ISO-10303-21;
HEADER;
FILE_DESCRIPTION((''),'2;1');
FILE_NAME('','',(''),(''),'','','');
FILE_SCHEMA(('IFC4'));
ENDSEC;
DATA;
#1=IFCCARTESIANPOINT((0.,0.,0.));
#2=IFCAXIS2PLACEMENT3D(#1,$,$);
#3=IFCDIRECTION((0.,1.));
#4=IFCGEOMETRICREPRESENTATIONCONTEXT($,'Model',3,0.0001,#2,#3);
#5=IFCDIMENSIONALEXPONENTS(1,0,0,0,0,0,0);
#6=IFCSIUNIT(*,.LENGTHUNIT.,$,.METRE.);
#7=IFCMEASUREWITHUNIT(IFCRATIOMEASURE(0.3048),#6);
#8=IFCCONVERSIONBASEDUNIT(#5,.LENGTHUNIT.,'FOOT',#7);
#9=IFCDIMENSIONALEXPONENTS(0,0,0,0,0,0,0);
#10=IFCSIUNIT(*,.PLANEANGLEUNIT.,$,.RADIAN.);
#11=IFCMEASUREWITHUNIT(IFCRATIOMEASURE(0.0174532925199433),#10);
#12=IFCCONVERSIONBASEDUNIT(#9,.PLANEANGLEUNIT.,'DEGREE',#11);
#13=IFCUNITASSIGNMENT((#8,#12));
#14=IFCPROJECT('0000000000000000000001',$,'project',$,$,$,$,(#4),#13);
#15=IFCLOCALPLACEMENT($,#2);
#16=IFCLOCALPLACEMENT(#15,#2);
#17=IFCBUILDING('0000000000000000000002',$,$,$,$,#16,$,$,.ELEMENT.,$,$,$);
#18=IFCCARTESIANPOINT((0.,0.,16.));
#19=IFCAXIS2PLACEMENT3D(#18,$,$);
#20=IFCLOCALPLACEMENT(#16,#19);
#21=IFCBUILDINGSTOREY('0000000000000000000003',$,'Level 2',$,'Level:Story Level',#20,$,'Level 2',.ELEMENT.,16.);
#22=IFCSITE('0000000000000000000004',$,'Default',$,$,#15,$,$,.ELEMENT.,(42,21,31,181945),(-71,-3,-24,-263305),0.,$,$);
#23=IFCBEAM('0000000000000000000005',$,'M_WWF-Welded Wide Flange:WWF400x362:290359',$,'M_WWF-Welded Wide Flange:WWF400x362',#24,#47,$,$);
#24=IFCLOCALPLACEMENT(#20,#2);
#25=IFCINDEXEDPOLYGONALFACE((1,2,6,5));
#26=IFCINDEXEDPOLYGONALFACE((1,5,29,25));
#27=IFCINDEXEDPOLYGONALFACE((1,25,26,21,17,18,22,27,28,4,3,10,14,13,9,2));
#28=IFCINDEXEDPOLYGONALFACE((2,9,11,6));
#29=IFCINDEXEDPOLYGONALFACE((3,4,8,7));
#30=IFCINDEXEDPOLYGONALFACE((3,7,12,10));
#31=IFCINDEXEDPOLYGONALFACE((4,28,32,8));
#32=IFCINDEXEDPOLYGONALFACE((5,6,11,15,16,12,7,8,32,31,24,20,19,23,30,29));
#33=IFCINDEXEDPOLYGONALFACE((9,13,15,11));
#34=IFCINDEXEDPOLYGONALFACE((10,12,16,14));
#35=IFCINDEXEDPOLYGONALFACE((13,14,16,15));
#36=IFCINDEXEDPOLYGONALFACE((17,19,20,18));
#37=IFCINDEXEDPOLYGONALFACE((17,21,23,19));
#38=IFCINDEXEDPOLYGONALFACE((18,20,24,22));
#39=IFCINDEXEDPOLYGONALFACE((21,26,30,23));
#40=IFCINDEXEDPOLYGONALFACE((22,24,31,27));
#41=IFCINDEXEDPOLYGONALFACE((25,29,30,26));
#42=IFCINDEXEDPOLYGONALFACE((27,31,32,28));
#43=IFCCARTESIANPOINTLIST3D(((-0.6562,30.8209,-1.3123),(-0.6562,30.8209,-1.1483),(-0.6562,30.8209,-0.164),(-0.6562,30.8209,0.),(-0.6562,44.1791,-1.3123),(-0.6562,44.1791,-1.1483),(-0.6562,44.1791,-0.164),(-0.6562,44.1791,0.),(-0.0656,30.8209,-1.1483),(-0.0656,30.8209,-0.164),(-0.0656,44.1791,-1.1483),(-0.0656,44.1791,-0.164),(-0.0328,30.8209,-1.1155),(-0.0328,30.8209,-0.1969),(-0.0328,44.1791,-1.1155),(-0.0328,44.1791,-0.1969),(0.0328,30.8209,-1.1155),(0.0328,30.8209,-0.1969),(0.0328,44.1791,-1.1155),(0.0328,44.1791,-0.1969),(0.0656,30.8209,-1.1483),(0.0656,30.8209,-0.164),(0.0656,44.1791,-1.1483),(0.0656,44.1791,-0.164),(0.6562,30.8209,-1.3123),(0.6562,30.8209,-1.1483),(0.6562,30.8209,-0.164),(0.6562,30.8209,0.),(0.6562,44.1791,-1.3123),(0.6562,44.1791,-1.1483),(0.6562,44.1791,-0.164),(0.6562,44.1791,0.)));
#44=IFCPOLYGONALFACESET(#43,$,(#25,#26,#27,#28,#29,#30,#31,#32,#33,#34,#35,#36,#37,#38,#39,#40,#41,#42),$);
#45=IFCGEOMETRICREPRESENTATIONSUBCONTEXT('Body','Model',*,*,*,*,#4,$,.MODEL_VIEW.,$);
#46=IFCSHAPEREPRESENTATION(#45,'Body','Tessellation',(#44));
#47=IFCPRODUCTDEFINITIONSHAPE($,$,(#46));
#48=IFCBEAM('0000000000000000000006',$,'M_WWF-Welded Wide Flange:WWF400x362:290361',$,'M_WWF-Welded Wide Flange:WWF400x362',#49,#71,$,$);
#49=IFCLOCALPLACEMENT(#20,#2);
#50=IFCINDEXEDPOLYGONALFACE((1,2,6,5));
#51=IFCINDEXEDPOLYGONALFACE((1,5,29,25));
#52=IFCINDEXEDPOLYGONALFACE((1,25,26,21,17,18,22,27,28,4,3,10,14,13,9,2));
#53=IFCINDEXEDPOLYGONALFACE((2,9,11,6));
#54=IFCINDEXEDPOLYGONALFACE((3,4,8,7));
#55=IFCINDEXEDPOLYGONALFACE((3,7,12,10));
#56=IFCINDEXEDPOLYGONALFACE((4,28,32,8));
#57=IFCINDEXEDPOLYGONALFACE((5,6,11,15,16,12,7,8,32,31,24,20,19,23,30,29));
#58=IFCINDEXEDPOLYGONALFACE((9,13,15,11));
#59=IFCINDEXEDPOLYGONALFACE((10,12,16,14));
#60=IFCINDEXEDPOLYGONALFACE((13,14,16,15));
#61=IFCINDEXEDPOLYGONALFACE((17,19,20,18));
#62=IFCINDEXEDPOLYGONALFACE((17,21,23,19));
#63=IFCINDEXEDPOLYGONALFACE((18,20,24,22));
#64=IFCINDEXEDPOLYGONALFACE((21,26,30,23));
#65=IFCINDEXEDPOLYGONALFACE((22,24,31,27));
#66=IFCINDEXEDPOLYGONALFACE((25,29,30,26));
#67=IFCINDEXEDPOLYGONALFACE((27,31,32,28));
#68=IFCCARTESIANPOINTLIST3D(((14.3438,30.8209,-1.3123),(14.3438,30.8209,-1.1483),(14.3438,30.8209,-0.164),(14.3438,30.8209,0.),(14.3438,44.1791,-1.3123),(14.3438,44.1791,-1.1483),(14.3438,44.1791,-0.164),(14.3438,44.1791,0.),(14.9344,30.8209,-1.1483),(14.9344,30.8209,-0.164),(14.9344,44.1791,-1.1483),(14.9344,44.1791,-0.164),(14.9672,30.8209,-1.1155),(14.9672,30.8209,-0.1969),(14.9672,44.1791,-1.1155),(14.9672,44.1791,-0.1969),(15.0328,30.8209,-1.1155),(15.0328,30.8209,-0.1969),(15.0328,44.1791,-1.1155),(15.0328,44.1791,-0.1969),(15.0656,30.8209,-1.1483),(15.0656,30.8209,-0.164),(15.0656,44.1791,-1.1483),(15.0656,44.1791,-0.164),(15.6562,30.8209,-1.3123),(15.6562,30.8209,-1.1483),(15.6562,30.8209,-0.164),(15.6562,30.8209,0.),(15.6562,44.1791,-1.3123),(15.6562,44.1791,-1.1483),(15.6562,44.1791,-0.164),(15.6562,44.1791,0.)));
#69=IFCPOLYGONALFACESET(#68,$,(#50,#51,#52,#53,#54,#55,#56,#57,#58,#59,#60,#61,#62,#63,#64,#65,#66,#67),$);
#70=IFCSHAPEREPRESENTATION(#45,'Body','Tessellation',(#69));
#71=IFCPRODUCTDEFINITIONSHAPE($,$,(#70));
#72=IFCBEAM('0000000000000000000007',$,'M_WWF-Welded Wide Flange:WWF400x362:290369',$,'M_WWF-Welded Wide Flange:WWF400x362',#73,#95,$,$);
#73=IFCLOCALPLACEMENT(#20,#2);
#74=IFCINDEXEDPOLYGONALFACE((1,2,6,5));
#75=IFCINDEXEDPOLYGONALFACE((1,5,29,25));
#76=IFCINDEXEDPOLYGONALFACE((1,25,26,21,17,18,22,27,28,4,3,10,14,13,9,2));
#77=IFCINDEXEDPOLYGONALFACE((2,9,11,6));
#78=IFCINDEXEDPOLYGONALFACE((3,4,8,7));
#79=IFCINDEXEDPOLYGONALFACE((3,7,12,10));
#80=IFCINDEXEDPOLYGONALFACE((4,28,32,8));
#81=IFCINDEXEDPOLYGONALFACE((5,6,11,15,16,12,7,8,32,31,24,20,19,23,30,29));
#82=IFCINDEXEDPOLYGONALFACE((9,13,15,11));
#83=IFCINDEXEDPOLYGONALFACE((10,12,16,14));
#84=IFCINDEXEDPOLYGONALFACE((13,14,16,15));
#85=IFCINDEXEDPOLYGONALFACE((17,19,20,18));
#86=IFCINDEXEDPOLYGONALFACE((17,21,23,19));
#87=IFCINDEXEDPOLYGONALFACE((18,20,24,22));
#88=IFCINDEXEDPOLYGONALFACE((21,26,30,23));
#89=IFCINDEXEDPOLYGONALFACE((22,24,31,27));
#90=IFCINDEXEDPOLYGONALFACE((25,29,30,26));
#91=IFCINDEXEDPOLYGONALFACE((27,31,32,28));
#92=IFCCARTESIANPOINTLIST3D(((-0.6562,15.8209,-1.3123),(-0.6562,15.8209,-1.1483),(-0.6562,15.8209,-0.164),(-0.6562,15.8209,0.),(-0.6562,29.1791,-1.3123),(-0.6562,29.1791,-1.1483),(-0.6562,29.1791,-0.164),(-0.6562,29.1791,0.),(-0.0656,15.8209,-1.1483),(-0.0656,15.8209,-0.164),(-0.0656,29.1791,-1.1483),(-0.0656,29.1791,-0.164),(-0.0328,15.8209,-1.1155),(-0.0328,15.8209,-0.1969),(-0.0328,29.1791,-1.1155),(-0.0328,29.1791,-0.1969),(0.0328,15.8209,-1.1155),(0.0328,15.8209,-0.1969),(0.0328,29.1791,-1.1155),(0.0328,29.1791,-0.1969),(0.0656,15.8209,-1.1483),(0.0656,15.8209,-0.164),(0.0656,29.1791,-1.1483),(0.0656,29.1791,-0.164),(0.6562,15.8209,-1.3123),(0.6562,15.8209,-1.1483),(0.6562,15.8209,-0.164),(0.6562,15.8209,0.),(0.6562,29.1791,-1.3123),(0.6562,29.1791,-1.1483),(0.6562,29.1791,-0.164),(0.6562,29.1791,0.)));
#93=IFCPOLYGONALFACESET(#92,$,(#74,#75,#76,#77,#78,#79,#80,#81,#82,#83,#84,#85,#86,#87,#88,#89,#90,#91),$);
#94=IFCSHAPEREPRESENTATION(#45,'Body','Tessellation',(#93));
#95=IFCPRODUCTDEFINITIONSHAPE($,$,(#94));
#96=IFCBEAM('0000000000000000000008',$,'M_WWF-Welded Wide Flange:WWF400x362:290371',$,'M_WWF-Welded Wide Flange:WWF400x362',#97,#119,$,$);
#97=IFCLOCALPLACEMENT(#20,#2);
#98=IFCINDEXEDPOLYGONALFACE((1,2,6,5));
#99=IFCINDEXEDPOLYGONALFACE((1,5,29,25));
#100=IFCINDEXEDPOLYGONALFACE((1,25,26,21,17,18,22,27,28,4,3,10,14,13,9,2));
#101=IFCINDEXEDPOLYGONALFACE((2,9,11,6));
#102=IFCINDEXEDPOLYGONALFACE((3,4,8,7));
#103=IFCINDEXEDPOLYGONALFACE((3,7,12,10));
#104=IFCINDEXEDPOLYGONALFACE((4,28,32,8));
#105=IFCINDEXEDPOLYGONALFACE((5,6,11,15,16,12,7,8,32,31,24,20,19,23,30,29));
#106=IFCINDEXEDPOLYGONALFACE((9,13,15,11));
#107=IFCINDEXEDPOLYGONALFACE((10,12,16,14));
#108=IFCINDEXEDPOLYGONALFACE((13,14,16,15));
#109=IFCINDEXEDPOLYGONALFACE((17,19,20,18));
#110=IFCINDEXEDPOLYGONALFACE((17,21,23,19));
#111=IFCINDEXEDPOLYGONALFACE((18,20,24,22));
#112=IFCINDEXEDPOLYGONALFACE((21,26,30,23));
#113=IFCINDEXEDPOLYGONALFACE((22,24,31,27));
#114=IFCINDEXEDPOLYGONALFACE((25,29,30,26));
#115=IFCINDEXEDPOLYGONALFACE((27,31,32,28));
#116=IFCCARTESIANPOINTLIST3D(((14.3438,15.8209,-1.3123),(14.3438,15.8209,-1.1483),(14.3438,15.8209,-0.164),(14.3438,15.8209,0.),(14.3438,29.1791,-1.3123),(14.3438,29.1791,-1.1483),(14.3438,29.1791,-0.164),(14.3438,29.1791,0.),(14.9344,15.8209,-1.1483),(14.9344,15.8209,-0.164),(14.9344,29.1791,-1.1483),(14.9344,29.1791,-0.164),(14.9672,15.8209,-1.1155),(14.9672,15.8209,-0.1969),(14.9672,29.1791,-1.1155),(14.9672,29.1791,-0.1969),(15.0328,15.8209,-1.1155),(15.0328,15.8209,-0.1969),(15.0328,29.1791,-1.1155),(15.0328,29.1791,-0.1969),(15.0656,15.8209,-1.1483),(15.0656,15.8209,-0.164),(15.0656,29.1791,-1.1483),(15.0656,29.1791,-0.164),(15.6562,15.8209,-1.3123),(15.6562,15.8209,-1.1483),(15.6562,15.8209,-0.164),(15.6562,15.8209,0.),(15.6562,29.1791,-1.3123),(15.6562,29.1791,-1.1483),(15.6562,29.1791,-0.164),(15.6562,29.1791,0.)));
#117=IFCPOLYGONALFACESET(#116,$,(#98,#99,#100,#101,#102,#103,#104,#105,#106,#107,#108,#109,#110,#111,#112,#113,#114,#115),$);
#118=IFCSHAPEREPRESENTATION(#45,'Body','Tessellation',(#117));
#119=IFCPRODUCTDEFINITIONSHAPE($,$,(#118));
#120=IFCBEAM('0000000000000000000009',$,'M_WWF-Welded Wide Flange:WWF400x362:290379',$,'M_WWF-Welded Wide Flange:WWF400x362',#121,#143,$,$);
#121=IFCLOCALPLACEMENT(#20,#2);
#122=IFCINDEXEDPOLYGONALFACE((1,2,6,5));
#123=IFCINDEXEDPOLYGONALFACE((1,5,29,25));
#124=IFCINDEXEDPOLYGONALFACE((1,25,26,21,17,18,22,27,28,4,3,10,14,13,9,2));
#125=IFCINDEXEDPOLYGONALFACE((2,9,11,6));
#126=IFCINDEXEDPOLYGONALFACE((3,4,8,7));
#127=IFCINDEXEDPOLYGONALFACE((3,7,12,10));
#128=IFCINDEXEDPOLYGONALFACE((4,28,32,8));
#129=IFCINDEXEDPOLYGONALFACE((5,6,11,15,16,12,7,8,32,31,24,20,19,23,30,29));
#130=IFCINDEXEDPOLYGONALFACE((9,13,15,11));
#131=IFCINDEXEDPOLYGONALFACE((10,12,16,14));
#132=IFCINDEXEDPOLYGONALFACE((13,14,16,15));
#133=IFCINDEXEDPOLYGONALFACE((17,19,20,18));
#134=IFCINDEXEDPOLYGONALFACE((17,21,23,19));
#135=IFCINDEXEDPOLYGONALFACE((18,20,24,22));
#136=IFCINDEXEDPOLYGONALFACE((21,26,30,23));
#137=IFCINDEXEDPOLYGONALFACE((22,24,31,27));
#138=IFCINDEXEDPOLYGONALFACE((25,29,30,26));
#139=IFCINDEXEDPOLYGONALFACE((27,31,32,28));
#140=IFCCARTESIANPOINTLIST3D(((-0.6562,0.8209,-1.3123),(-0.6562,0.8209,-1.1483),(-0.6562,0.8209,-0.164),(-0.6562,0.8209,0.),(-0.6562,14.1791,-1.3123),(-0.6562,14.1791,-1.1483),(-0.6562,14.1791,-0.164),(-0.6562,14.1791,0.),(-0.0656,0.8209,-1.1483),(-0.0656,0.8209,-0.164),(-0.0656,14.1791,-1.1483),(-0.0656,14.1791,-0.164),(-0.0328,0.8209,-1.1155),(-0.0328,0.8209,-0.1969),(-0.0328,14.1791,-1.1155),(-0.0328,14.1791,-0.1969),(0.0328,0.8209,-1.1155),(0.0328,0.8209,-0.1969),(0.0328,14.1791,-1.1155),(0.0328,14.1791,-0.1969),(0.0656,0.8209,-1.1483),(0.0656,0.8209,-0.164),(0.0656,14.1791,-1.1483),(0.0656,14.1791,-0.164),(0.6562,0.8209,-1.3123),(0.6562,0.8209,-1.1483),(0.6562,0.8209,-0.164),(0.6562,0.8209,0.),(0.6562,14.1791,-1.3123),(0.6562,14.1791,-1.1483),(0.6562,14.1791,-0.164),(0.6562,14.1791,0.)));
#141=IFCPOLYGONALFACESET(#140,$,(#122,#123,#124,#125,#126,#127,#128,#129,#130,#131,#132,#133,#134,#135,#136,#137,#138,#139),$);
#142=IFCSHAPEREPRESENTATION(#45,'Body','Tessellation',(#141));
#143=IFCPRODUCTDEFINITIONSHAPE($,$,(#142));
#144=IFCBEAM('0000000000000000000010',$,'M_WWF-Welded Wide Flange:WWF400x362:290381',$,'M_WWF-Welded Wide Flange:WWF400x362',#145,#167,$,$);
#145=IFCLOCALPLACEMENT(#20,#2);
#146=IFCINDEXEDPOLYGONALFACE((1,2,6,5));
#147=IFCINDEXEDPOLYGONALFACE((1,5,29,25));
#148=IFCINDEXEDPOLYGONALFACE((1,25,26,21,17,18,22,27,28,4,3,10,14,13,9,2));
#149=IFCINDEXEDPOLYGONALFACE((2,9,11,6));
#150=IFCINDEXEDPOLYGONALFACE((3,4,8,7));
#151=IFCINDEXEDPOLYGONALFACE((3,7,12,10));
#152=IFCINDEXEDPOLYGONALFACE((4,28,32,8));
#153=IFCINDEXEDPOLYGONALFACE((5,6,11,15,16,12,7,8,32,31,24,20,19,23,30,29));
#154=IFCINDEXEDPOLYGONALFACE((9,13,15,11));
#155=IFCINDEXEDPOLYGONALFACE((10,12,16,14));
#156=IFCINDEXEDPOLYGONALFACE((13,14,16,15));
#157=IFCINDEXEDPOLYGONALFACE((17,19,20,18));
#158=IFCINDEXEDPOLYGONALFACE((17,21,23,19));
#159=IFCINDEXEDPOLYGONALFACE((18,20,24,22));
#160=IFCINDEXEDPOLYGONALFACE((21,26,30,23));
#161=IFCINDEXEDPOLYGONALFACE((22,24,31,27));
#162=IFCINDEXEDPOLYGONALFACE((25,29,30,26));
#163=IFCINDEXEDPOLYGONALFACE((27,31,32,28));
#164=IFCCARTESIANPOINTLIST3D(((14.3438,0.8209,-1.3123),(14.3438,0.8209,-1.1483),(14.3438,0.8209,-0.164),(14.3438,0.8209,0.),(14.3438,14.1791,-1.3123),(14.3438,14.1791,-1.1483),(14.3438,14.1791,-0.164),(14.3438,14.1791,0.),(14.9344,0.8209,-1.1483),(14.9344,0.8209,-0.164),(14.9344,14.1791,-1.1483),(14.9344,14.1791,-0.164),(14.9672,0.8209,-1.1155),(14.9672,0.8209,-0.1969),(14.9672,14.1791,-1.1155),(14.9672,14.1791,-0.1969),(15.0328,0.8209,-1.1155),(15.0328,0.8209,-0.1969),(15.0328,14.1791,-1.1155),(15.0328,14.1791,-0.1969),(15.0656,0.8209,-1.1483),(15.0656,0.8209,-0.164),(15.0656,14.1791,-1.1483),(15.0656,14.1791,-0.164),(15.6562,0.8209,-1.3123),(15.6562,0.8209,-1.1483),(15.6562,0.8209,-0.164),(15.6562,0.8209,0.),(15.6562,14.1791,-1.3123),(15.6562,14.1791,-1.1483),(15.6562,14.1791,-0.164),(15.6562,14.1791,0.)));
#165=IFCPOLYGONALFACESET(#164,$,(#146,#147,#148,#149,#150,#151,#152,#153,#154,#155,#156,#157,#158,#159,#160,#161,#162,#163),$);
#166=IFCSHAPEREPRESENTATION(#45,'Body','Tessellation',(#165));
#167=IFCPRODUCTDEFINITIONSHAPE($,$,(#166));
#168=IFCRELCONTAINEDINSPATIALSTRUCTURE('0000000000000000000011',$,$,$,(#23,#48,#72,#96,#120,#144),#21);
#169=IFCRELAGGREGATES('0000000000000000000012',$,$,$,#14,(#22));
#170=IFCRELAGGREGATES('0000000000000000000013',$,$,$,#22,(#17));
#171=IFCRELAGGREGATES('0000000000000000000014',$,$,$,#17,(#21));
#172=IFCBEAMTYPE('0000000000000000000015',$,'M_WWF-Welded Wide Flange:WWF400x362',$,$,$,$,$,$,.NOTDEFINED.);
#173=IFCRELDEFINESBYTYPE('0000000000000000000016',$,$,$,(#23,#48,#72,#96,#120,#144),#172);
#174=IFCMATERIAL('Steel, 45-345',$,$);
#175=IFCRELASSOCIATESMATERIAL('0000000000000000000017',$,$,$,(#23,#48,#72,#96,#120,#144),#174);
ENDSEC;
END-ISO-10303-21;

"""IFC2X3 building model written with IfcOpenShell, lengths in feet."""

from ifc_helpers import new_model, entity, si_unit, converted_unit, direction, frame, origin, place, context, subcontext, project, spatial, polyline, outline, extrude, material, type_object, element, save


model = new_model("IFC2X3")

# Units and contexts
model_context = context("Model", 3, precision=0.0001, world=origin(), true_north=direction((0.0, 1.0)))
body_context = subcontext(model_context, "Body", "Model", "MODEL_VIEW")
ifc_project = project(units=[converted_unit("LENGTHUNIT", "FOOT", entity("IfcRatioMeasure", 0.3048), si_unit("LENGTHUNIT", "METRE"), dimensions=[1, 0, 0, 0, 0, 0, 0]), converted_unit("PLANEANGLEUNIT", "DEGREE", entity("IfcRatioMeasure", 0.0174532925199433), si_unit("PLANEANGLEUNIT", "RADIAN"), dimensions=[0, 0, 0, 0, 0, 0, 0])], contexts=[model_context])

# Site, building, storey
site_placement = place(None, origin())
site = spatial("IfcSite", under=ifc_project, at=site_placement, Name="Default", CompositionType="ELEMENT", RefLatitude=(42, 21, 31, 181945), RefLongitude=(-71, -3, -24, -263305), RefElevation=0.0)
building_placement = place(site_placement, origin())
building = spatial("IfcBuilding", under=site, at=building_placement, CompositionType="ELEMENT")
storey_placement = place(building_placement, frame((0.0, 0.0, 16.0)))
storey = spatial("IfcBuildingStorey", under=building, at=storey_placement, Name="Level 2", ObjectType="Level:Story Level", LongName="Level 2", CompositionType="ELEMENT", Elevation=16.0)

# Shared definitions
ifc_material = material(Name="Steel, 45-345")

# Beams
beam_type = type_object("IfcBeamType", Name="M_WWF-Welded Wide Flange:WWF400x362", PredefinedType="NOTDEFINED")
beam_1_placement = place(storey_placement, frame((0.0, 30.0, 0.0), z_axis=(0.0, 0.0, 1.0), x_axis=(0.0, 1.0, 0.0)))
element("IfcBeam", 1, at=beam_1_placement, inside=storey, type_object=beam_type, material=ifc_material, Name="M_WWF-Welded Wide Flange:WWF400x362:290359", ObjectType="M_WWF-Welded Wide Flange:WWF400x362", context=body_context, shape_type="SweptSolid", body=[
    extrude(outline(polyline([(-0.6562, -0.6562), (-0.4921, -0.6562), (-0.4921, -0.0656), (-0.4593, -0.0328), (0.4593, -0.0328), (0.4921, -0.0656), (0.4921, -0.6562), (0.6562, -0.6562), (0.6562, 0.6562), (0.4921, 0.6562), (0.4921, 0.0656), (0.4593, 0.0328), (-0.4593, 0.0328), (-0.4921, 0.0656), (-0.4921, 0.6562), (-0.6562, 0.6562), (-0.6562, -0.6562)])), frame((0.8209, 0.0, -0.6562), z_axis=(1.0, 0.0, 0.0), x_axis=(0.0, 0.0, -1.0)), (0.0, 0.0, 1.0), 13.3583),
])
beam_2_placement = place(storey_placement, frame((15.0, 30.0, 0.0), z_axis=(0.0, 0.0, 1.0), x_axis=(0.0, 1.0, 0.0)))
element("IfcBeam", 2, at=beam_2_placement, inside=storey, type_object=beam_type, material=ifc_material, Name="M_WWF-Welded Wide Flange:WWF400x362:290361", ObjectType="M_WWF-Welded Wide Flange:WWF400x362", context=body_context, shape_type="SweptSolid", body=[
    extrude(outline(polyline([(-0.6562, -0.6562), (-0.4921, -0.6562), (-0.4921, -0.0656), (-0.4593, -0.0328), (0.4593, -0.0328), (0.4921, -0.0656), (0.4921, -0.6562), (0.6562, -0.6562), (0.6562, 0.6562), (0.4921, 0.6562), (0.4921, 0.0656), (0.4593, 0.0328), (-0.4593, 0.0328), (-0.4921, 0.0656), (-0.4921, 0.6562), (-0.6562, 0.6562), (-0.6562, -0.6562)])), frame((0.8209, 0.0, -0.6562), z_axis=(1.0, 0.0, 0.0), x_axis=(0.0, 0.0, -1.0)), (0.0, 0.0, 1.0), 13.3583),
])
beam_3_placement = place(storey_placement, frame((0.0, 15.0, 0.0), z_axis=(0.0, 0.0, 1.0), x_axis=(0.0, 1.0, 0.0)))
element("IfcBeam", 3, at=beam_3_placement, inside=storey, type_object=beam_type, material=ifc_material, Name="M_WWF-Welded Wide Flange:WWF400x362:290369", ObjectType="M_WWF-Welded Wide Flange:WWF400x362", context=body_context, shape_type="SweptSolid", body=[
    extrude(outline(polyline([(-0.6562, -0.6562), (-0.4921, -0.6562), (-0.4921, -0.0656), (-0.4593, -0.0328), (0.4593, -0.0328), (0.4921, -0.0656), (0.4921, -0.6562), (0.6562, -0.6562), (0.6562, 0.6562), (0.4921, 0.6562), (0.4921, 0.0656), (0.4593, 0.0328), (-0.4593, 0.0328), (-0.4921, 0.0656), (-0.4921, 0.6562), (-0.6562, 0.6562), (-0.6562, -0.6562)])), frame((0.8209, 0.0, -0.6562), z_axis=(1.0, 0.0, 0.0), x_axis=(0.0, 0.0, -1.0)), (0.0, 0.0, 1.0), 13.3583),
])
beam_4_placement = place(storey_placement, frame((15.0, 15.0, 0.0), z_axis=(0.0, 0.0, 1.0), x_axis=(0.0, 1.0, 0.0)))
element("IfcBeam", 4, at=beam_4_placement, inside=storey, type_object=beam_type, material=ifc_material, Name="M_WWF-Welded Wide Flange:WWF400x362:290371", ObjectType="M_WWF-Welded Wide Flange:WWF400x362", context=body_context, shape_type="SweptSolid", body=[
    extrude(outline(polyline([(-0.6562, -0.6562), (-0.4921, -0.6562), (-0.4921, -0.0656), (-0.4593, -0.0328), (0.4593, -0.0328), (0.4921, -0.0656), (0.4921, -0.6562), (0.6562, -0.6562), (0.6562, 0.6562), (0.4921, 0.6562), (0.4921, 0.0656), (0.4593, 0.0328), (-0.4593, 0.0328), (-0.4921, 0.0656), (-0.4921, 0.6562), (-0.6562, 0.6562), (-0.6562, -0.6562)])), frame((0.8209, 0.0, -0.6562), z_axis=(1.0, 0.0, 0.0), x_axis=(0.0, 0.0, -1.0)), (0.0, 0.0, 1.0), 13.3583),
])
beam_5_placement = place(storey_placement, frame((0.0, 0.0, 0.0), z_axis=(0.0, 0.0, 1.0), x_axis=(0.0, 1.0, 0.0)))
element("IfcBeam", 5, at=beam_5_placement, inside=storey, type_object=beam_type, material=ifc_material, Name="M_WWF-Welded Wide Flange:WWF400x362:290379", ObjectType="M_WWF-Welded Wide Flange:WWF400x362", context=body_context, shape_type="SweptSolid", body=[
    extrude(outline(polyline([(-0.6562, -0.6562), (-0.4921, -0.6562), (-0.4921, -0.0656), (-0.4593, -0.0328), (0.4593, -0.0328), (0.4921, -0.0656), (0.4921, -0.6562), (0.6562, -0.6562), (0.6562, 0.6562), (0.4921, 0.6562), (0.4921, 0.0656), (0.4593, 0.0328), (-0.4593, 0.0328), (-0.4921, 0.0656), (-0.4921, 0.6562), (-0.6562, 0.6562), (-0.6562, -0.6562)])), frame((0.8209, 0.0, -0.6562), z_axis=(1.0, 0.0, 0.0), x_axis=(0.0, 0.0, -1.0)), (0.0, 0.0, 1.0), 13.3583),
])
beam_6_placement = place(storey_placement, frame((15.0, 0.0, 0.0), z_axis=(0.0, 0.0, 1.0), x_axis=(0.0, 1.0, 0.0)))
element("IfcBeam", 6, at=beam_6_placement, inside=storey, type_object=beam_type, material=ifc_material, Name="M_WWF-Welded Wide Flange:WWF400x362:290381", ObjectType="M_WWF-Welded Wide Flange:WWF400x362", context=body_context, shape_type="SweptSolid", body=[
    extrude(outline(polyline([(-0.6562, -0.6562), (-0.4921, -0.6562), (-0.4921, -0.0656), (-0.4593, -0.0328), (0.4593, -0.0328), (0.4921, -0.0656), (0.4921, -0.6562), (0.6562, -0.6562), (0.6562, 0.6562), (0.4921, 0.6562), (0.4921, 0.0656), (0.4593, 0.0328), (-0.4593, 0.0328), (-0.4921, 0.0656), (-0.4921, 0.6562), (-0.6562, 0.6562), (-0.6562, -0.6562)])), frame((0.8209, 0.0, -0.6562), z_axis=(1.0, 0.0, 0.0), x_axis=(0.0, 0.0, -1.0)), (0.0, 0.0, 1.0), 13.3583),
])

save(model, "model.ifc")
